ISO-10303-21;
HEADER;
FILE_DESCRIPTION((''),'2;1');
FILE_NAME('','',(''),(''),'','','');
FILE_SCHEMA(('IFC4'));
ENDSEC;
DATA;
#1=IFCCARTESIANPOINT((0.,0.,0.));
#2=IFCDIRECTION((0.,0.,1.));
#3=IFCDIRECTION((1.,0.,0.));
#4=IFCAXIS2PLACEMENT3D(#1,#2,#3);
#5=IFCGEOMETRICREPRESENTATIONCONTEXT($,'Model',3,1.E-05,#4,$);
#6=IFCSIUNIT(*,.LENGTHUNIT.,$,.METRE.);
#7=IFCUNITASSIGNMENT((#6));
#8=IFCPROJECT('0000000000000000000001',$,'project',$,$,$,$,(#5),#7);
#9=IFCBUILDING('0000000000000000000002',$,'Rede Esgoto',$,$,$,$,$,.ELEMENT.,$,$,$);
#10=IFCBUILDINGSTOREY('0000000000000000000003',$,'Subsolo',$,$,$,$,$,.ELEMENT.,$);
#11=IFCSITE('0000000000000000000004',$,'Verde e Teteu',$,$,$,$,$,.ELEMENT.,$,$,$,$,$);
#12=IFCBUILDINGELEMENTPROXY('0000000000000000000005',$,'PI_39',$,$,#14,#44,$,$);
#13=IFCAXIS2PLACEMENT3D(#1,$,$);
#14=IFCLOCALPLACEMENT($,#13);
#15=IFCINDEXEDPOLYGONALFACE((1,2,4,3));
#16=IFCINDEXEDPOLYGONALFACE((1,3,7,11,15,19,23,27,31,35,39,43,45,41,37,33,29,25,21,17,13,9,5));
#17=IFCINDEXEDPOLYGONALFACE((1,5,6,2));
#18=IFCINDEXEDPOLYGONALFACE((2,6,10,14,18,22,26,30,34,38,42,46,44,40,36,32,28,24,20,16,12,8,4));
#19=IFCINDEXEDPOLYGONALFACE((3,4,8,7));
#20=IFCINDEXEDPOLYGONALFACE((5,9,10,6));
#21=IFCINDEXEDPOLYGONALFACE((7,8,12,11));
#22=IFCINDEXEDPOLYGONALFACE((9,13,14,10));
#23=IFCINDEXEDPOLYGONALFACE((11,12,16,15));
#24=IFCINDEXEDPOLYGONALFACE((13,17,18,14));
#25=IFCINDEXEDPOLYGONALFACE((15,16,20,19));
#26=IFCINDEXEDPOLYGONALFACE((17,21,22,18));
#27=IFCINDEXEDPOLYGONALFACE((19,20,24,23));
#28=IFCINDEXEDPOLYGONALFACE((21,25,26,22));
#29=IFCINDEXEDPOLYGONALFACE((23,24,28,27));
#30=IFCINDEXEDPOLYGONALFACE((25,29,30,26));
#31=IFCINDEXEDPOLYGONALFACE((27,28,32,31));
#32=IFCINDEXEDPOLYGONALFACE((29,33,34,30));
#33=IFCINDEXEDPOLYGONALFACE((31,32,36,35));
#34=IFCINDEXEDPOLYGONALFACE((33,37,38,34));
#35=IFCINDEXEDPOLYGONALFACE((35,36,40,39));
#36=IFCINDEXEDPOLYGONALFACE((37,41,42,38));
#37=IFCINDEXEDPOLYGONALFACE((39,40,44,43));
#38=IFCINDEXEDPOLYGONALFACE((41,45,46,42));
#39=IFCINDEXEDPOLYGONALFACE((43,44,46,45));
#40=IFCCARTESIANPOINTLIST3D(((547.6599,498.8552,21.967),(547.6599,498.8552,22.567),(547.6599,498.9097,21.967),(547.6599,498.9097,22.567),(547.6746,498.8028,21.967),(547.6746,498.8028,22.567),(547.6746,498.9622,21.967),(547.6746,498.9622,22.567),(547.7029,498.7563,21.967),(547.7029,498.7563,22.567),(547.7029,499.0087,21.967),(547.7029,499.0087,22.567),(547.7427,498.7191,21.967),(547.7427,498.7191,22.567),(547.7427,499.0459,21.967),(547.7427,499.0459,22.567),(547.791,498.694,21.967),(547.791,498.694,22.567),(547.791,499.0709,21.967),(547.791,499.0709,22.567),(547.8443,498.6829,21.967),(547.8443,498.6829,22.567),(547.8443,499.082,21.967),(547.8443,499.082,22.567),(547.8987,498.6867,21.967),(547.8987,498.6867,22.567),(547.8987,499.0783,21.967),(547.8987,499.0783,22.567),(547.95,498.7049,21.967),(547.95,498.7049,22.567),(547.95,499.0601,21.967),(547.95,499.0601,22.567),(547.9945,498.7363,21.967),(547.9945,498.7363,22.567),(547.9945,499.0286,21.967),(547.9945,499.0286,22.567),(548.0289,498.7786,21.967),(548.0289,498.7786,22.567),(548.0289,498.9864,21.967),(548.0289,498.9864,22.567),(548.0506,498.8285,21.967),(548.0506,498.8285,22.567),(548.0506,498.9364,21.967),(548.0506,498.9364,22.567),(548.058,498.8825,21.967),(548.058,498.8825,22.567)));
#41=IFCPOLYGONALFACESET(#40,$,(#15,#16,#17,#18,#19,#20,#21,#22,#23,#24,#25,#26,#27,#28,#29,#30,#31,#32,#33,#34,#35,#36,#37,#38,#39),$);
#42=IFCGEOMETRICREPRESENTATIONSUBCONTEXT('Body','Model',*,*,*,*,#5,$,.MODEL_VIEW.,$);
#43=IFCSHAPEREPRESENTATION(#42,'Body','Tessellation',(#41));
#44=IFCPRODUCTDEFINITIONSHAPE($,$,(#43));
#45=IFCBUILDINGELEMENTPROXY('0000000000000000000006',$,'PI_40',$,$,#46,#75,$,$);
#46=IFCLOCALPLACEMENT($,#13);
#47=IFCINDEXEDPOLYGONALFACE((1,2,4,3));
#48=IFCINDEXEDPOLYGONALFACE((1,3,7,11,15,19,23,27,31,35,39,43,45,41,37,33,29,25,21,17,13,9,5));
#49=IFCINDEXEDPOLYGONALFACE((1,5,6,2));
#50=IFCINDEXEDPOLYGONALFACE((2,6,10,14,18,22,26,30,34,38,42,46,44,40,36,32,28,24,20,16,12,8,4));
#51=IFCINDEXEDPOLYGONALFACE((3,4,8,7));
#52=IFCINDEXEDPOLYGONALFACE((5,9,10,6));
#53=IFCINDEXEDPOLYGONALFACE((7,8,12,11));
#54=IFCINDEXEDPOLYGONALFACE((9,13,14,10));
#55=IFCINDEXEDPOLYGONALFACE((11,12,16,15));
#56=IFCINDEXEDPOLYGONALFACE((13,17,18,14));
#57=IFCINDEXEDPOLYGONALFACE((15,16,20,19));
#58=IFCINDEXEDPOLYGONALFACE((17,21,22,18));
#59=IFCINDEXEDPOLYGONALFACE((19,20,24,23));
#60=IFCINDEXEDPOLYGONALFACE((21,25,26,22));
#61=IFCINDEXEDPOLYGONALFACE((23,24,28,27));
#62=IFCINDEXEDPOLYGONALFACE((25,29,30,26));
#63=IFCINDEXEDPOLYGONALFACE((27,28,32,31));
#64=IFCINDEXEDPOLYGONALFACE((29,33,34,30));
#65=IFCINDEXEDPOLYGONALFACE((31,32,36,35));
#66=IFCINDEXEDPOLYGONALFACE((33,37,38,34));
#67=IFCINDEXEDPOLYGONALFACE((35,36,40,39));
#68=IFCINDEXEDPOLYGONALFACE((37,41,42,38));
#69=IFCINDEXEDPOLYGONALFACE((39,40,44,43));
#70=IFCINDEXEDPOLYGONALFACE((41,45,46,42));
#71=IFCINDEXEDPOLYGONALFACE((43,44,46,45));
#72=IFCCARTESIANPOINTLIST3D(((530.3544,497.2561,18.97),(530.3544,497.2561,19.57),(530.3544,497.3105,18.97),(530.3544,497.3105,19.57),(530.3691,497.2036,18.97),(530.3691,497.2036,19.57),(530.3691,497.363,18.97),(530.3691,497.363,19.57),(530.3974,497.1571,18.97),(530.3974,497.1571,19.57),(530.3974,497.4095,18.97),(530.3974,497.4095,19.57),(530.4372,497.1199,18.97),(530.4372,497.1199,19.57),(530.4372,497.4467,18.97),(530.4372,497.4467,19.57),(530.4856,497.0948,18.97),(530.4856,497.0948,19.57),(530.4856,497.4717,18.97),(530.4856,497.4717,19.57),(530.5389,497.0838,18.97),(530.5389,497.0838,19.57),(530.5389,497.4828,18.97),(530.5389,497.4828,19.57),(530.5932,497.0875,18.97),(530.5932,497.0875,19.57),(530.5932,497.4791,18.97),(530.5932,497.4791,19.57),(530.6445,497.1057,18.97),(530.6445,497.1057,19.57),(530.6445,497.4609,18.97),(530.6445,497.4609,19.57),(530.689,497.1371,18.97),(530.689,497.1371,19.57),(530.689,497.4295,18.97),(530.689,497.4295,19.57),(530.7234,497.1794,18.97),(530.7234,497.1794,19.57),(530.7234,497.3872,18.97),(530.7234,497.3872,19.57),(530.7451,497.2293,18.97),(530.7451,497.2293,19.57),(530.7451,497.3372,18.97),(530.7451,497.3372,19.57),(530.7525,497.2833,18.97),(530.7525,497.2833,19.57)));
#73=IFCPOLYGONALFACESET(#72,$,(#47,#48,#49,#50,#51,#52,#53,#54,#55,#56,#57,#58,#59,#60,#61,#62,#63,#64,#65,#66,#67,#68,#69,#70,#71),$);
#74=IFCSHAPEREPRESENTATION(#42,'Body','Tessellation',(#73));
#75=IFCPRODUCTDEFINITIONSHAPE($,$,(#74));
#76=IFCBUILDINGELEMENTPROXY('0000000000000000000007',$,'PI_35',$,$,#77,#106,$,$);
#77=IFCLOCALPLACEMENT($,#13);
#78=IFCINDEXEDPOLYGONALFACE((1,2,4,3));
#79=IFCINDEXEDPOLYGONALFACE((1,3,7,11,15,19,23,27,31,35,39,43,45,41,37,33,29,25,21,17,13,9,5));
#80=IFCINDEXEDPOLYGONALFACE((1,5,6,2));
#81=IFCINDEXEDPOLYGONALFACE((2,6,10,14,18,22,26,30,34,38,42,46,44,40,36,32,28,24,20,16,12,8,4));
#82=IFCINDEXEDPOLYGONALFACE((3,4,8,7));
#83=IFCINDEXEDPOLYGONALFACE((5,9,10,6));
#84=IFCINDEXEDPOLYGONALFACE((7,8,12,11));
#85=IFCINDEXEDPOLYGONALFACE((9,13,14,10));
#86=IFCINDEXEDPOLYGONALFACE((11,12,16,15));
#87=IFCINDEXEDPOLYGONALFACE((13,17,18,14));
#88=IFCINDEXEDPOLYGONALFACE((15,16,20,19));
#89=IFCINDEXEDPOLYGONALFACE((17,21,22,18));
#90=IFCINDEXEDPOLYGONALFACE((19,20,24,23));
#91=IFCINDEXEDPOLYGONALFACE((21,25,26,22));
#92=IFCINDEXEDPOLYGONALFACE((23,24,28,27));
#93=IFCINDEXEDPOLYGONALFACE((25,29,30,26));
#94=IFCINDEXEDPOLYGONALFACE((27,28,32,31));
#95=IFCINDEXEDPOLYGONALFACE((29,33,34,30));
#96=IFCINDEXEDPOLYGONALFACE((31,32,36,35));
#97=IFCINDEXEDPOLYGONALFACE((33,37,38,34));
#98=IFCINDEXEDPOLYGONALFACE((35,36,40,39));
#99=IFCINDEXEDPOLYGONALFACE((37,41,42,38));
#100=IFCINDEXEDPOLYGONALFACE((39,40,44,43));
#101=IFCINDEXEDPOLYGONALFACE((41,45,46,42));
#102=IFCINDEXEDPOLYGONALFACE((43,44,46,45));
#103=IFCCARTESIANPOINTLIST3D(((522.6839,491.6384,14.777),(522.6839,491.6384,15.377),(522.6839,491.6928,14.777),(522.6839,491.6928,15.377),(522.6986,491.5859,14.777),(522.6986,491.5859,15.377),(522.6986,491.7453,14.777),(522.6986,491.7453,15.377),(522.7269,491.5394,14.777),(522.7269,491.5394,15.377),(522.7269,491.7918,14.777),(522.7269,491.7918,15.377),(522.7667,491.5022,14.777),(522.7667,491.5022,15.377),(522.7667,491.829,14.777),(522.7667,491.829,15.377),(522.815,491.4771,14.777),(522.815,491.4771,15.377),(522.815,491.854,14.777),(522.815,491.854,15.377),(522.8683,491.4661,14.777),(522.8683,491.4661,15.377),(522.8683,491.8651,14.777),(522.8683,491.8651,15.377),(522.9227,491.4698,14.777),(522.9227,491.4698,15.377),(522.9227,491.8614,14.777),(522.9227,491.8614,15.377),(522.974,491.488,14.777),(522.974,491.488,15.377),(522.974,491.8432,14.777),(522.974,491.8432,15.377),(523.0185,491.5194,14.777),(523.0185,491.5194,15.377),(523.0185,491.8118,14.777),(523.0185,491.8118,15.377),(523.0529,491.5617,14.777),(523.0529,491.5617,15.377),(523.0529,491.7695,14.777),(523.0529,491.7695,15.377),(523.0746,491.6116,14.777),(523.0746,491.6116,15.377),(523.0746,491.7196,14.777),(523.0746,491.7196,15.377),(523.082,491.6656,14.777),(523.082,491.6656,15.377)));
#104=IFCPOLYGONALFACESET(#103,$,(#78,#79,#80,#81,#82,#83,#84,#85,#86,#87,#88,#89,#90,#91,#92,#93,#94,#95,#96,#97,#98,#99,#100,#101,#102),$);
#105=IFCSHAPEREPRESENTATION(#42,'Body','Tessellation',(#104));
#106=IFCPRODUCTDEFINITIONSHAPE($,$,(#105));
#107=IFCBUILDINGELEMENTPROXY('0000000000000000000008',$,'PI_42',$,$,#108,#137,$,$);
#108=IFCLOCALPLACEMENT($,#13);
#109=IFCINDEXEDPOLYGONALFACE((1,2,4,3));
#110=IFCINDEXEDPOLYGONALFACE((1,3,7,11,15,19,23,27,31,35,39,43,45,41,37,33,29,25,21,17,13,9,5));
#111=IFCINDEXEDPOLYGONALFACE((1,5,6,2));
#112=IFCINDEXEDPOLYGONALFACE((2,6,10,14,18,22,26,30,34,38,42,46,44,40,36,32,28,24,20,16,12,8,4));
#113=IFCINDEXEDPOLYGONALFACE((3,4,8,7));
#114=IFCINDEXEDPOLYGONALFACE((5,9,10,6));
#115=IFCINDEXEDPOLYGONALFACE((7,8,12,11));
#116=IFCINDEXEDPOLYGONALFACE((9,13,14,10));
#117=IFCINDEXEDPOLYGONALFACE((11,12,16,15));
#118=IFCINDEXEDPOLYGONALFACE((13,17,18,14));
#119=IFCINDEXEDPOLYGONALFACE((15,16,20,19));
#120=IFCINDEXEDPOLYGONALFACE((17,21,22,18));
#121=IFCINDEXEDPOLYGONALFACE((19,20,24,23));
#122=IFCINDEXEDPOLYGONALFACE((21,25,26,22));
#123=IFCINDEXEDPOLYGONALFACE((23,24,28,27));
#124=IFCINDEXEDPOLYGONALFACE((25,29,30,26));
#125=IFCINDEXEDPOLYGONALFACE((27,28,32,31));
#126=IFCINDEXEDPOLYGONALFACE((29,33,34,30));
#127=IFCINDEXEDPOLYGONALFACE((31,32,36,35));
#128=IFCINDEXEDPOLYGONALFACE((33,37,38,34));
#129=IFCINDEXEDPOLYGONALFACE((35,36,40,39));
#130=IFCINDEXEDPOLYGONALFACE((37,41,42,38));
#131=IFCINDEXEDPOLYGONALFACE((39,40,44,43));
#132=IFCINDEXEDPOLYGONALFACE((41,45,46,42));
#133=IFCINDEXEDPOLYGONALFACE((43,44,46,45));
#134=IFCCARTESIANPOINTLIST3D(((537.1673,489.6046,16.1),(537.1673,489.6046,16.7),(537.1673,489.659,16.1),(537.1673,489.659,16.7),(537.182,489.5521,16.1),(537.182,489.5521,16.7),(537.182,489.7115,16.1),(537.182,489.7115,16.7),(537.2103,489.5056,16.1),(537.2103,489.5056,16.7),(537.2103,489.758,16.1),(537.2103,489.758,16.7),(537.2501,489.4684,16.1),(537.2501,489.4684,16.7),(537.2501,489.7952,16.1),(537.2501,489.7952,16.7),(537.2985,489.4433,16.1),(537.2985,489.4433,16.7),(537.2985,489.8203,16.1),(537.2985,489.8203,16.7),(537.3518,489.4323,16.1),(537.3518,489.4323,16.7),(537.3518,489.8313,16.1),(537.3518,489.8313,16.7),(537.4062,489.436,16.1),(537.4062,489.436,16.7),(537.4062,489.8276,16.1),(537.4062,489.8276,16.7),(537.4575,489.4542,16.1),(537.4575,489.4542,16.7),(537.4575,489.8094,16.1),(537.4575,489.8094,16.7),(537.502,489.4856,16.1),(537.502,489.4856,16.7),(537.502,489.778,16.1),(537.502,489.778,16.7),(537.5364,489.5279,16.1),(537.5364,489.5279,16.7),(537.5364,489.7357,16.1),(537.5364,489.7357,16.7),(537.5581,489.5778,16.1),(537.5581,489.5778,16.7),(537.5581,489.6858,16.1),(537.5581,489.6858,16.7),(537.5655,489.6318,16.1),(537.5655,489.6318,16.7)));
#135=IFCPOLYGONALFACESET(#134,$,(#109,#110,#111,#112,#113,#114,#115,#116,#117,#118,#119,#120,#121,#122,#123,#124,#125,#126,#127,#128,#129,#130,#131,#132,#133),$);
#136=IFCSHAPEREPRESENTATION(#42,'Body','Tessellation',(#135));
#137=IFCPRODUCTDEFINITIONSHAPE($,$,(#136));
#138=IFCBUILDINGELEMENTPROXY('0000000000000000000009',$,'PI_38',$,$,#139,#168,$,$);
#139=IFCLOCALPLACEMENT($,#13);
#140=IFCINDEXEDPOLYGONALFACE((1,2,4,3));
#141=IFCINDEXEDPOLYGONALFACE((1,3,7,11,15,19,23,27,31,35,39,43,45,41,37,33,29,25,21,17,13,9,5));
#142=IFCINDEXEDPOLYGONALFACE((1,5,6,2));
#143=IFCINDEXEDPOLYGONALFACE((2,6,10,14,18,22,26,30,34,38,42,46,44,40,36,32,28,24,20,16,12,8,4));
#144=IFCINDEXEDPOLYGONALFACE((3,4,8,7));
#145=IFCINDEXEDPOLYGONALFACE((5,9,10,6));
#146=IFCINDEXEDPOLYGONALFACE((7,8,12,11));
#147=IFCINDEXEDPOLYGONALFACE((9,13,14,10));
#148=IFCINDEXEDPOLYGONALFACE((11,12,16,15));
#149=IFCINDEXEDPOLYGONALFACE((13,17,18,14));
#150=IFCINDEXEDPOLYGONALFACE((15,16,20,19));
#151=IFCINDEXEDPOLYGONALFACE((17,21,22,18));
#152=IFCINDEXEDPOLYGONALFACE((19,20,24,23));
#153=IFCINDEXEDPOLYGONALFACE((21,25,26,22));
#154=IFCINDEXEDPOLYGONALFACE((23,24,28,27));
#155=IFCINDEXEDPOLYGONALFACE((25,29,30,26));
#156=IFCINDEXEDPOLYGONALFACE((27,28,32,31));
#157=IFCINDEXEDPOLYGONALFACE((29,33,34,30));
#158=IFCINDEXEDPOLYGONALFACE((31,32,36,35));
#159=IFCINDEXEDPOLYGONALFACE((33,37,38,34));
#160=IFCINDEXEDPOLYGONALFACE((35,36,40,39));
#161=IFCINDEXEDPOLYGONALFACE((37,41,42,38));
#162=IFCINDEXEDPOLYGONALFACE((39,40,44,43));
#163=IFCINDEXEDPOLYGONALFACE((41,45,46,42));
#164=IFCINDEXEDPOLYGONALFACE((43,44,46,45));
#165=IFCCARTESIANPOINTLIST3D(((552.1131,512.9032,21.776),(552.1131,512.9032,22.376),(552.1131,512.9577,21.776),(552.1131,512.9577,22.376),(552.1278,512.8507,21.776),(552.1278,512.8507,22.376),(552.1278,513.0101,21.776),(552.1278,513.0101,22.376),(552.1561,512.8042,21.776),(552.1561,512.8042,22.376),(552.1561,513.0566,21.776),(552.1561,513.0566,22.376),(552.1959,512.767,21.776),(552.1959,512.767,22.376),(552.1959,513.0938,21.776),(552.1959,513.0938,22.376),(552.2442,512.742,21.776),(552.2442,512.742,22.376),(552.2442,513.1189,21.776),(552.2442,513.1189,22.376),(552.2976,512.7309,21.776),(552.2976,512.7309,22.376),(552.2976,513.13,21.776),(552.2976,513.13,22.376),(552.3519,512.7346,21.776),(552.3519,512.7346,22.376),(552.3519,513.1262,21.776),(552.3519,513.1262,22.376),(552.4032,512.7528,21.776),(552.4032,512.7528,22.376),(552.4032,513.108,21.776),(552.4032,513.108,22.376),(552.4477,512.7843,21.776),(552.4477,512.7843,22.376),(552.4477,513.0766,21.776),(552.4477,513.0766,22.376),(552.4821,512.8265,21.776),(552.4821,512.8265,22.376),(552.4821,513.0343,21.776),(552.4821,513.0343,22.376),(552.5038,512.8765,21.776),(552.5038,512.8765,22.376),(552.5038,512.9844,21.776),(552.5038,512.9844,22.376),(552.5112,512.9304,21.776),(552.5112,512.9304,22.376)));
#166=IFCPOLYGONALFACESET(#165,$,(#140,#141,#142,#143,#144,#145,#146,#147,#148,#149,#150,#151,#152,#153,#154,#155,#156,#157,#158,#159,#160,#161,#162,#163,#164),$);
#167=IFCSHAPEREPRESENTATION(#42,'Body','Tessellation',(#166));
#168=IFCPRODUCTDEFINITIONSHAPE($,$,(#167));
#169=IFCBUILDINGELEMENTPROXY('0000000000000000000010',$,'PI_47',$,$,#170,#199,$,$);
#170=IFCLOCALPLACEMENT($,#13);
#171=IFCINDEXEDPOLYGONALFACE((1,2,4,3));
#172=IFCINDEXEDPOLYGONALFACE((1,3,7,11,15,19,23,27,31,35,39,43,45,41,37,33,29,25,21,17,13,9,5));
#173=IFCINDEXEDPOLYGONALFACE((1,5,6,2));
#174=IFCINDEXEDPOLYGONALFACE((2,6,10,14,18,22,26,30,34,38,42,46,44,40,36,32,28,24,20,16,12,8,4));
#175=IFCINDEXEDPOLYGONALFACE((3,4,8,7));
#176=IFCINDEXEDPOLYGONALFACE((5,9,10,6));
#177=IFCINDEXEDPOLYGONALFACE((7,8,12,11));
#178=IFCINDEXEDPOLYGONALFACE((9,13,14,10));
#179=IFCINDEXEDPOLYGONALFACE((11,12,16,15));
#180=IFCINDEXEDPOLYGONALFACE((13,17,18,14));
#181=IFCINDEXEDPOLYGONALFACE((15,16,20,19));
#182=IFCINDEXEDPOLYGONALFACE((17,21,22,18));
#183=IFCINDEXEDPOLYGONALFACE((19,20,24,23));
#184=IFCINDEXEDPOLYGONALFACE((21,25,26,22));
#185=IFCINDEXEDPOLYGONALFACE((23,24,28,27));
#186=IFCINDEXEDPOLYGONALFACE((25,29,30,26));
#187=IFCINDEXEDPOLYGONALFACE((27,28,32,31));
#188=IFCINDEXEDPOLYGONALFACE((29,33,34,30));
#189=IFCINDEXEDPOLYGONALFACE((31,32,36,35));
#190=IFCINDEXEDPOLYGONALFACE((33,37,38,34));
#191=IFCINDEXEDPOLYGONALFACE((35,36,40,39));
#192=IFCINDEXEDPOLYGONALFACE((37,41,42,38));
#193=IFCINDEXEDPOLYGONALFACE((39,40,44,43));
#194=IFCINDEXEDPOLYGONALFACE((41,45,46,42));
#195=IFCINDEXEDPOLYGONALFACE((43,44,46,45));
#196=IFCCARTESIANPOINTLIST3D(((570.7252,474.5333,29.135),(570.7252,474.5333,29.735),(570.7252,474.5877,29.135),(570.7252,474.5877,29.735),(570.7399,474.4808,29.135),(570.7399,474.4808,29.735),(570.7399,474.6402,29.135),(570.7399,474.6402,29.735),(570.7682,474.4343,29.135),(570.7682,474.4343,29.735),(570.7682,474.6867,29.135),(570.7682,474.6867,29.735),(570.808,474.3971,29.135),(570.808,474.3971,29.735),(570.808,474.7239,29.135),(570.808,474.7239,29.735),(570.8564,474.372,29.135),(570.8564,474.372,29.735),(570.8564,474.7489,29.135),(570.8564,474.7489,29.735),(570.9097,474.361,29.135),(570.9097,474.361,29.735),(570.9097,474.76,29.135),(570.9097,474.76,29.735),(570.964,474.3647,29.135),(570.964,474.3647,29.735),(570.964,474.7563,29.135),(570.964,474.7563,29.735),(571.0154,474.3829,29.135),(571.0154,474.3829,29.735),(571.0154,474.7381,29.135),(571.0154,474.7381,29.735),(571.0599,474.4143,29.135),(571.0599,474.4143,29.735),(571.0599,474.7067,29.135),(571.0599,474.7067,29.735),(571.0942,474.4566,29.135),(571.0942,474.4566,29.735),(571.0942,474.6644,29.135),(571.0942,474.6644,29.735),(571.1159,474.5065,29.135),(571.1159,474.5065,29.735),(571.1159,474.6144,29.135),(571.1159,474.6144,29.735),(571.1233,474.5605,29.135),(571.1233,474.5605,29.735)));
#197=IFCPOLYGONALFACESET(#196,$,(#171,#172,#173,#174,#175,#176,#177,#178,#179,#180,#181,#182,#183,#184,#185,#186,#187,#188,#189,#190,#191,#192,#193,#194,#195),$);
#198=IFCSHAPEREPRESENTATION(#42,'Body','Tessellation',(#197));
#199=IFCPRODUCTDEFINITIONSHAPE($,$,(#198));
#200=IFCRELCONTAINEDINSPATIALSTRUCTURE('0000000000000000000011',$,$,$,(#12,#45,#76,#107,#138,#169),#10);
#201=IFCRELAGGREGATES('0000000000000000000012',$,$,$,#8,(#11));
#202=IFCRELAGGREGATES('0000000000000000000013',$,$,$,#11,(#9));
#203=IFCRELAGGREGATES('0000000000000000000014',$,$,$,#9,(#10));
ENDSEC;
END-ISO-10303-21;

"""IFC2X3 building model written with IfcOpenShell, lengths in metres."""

from ifc_helpers import new_model, si_unit, frame, origin_with_axes, origin_2d, place, context, subcontext, project, spatial, circle, extrude, element, save


model = new_model("IFC2X3")

# Units and contexts
model_context = context("Model", 3, precision=1e-05, world=origin_with_axes())
body_context = subcontext(model_context, "Body", "Model", "MODEL_VIEW")
ifc_project = project(units=[si_unit("LENGTHUNIT", "METRE")], contexts=[model_context])

# Site, building, storey
site = spatial("IfcSite", under=ifc_project, Name="Verde e Teteu", CompositionType="ELEMENT")
building = spatial("IfcBuilding", under=site, Name="Rede Esgoto", CompositionType="ELEMENT")
storey = spatial("IfcBuildingStorey", under=building, Name="Subsolo", CompositionType="ELEMENT")

# Building element proxies
for number, where, z_axis, x_axis, name in (
    (1, (547.858, 498.8825, 21.967), (0.0, 0.0, 1.0), (1.0, 0.0, 0.0), "PI_39"),
    (2, (530.5525, 497.2833, 18.97), (0.0, 0.0, 1.0), (1.0, 0.0, 0.0), "PI_40"),
    (3, (522.882, 491.6656, 14.777), (0.0, 0.0, 1.0), (1.0, 0.0, 0.0), "PI_35"),
):
    element("IfcBuildingElementProxy", number, at=place(None, frame(where, z_axis=z_axis, x_axis=x_axis)), inside=storey, Name=name, context=body_context, shape_type="SweptSolid", body=[
        extrude(circle(Radius=0.2, at=origin_2d()), origin_with_axes(), (0.0, 0.0, 1.0), 0.6),
    ])
proxy_1_placement = place(None, frame((537.3655, 489.6318, 16.1), z_axis=(0.0, 0.0, 1.0), x_axis=(1.0, 0.0, 0.0)))
element("IfcBuildingElementProxy", 4, at=proxy_1_placement, inside=storey, Name="PI_42", context=body_context, shape_type="SweptSolid", body=[
    extrude(circle(Radius=0.2, at=origin_2d()), origin_with_axes(), (0.0, 0.0, 1.0), 0.6),
])
proxy_2_placement = place(None, frame((552.3112, 512.9304, 21.776), z_axis=(0.0, 0.0, 1.0), x_axis=(1.0, 0.0, 0.0)))
element("IfcBuildingElementProxy", 5, at=proxy_2_placement, inside=storey, Name="PI_38", context=body_context, shape_type="SweptSolid", body=[
    extrude(circle(Radius=0.2, at=origin_2d()), origin_with_axes(), (0.0, 0.0, 1.0), 0.6),
])
proxy_3_placement = place(None, frame((570.9233, 474.5605, 29.135), z_axis=(0.0, 0.0, 1.0), x_axis=(1.0, 0.0, 0.0)))
element("IfcBuildingElementProxy", 6, at=proxy_3_placement, inside=storey, Name="PI_47", context=body_context, shape_type="SweptSolid", body=[
    extrude(circle(Radius=0.2, at=origin_2d()), origin_with_axes(), (0.0, 0.0, 1.0), 0.6),
])

save(model, "model.ifc")
